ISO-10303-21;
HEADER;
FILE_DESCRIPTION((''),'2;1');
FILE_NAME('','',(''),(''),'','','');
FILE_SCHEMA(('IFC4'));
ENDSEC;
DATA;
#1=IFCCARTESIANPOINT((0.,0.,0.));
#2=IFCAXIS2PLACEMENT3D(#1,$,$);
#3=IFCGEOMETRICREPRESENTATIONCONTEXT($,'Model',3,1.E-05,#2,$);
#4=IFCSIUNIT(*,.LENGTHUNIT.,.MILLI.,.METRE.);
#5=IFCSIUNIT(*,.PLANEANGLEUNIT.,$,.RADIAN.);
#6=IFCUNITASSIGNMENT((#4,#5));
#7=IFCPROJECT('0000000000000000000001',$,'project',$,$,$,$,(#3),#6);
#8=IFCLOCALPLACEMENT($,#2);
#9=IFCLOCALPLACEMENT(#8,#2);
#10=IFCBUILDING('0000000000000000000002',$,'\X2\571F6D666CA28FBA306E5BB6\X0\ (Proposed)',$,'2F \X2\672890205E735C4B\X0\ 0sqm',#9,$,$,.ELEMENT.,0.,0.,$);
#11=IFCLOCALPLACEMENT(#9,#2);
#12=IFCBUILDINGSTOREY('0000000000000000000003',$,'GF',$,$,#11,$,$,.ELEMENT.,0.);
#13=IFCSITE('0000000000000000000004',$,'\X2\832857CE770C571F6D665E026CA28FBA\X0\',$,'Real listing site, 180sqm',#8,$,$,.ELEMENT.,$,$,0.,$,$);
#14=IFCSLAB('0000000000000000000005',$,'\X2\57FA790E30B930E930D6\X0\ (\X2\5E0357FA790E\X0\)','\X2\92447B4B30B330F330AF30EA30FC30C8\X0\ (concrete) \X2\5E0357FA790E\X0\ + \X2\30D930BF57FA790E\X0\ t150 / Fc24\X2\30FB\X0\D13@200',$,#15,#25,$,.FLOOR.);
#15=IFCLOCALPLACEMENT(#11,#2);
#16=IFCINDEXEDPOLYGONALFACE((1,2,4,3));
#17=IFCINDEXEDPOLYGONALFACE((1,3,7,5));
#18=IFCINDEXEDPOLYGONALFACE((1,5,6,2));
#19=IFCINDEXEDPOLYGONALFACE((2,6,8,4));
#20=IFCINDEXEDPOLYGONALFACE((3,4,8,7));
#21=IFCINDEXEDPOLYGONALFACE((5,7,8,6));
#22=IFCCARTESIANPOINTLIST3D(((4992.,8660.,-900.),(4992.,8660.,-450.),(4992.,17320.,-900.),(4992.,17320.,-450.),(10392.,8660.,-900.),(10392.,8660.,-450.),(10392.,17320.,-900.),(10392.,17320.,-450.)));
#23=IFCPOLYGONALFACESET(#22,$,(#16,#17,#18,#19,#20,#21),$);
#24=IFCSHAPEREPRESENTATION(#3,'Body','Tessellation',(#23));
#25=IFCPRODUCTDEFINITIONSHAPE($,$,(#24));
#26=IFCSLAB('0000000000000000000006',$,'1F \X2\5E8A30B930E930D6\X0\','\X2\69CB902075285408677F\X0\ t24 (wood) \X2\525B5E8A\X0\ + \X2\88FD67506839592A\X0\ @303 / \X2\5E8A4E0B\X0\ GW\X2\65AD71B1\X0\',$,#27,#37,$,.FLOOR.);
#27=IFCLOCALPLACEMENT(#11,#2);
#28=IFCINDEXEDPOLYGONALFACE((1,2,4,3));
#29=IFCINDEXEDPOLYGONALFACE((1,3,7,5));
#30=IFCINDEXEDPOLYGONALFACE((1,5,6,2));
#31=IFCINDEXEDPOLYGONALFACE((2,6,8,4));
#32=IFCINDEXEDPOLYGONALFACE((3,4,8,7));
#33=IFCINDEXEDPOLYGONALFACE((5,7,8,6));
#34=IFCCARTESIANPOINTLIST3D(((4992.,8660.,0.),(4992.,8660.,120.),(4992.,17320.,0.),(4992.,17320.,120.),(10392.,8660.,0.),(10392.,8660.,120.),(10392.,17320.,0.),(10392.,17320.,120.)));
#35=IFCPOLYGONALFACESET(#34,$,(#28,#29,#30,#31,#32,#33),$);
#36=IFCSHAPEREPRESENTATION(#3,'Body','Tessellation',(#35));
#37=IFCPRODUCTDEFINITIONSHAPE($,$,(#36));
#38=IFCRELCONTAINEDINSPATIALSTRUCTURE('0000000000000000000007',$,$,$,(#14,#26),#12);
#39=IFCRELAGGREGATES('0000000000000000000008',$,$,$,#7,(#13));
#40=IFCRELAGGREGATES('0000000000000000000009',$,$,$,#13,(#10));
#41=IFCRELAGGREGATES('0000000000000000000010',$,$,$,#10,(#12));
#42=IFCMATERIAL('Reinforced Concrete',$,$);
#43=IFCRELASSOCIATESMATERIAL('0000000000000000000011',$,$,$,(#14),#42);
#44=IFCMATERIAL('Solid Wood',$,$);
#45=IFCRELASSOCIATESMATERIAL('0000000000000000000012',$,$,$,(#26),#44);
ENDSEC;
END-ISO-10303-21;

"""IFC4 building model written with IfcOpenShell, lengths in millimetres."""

from ifc_helpers import new_model, si_unit, frame, frame_2d, origin, place, context, project, spatial, rectangle, extrude, material, element, save


model = new_model("IFC4")

# Units and contexts
model_context = context("Model", 3, precision=1e-05, world=origin())
ifc_project = project(units=[si_unit("LENGTHUNIT", "METRE", prefix="MILLI"), si_unit("PLANEANGLEUNIT", "RADIAN")], contexts=[model_context])

# Site, building, storey
site_placement = place(None, origin())
site = spatial("IfcSite", under=ifc_project, at=site_placement, Name="茨城県土浦市沢辺", ObjectType="Real listing site, 180sqm", CompositionType="ELEMENT", RefElevation=0.0)
building_placement = place(site_placement, origin())
building = spatial("IfcBuilding", under=site, at=building_placement, Name="土浦沢辺の家 (Proposed)", ObjectType="2F 木造平屋 0sqm", CompositionType="ELEMENT", ElevationOfRefHeight=0.0, ElevationOfTerrain=0.0)
storey_placement = place(building_placement, origin())
storey = spatial("IfcBuildingStorey", under=building, at=storey_placement, Name="GF", CompositionType="ELEMENT", Elevation=0.0)

# Slabs
ifc_material_1 = material(Name="Reinforced Concrete")
slab_1_placement = place(storey_placement, frame((2496.0, 4330.0, -450.0)))
element("IfcSlab", 1, at=slab_1_placement, inside=storey, material=ifc_material_1, Name="基礎スラブ (布基礎)", Description="鉄筋コンクリート (concrete) 布基礎 + ベタ基礎 t150 / Fc24・D13@200", PredefinedType="FLOOR", context=model_context, shape_type="SweptSolid", body=[
    extrude(rectangle(XDim=5400.0, YDim=8660.0, at=frame_2d((2700.0, 4330.0))), frame((2496.0, 4330.0, -450.0)), (0.0, 0.0, 1.0), 450.0),
])
ifc_material_2 = material(Name="Solid Wood")
slab_2_placement = place(storey_placement, frame((2496.0, 4330.0, 0.0)))
element("IfcSlab", 2, at=slab_2_placement, inside=storey, material=ifc_material_2, Name="1F 床スラブ", Description="構造用合板 t24 (wood) 剛床 + 製材根太 @303 / 床下 GW断熱", PredefinedType="FLOOR", context=model_context, shape_type="SweptSolid", body=[
    extrude(rectangle(XDim=5400.0, YDim=8660.0, at=frame_2d((2700.0, 4330.0))), frame((2496.0, 4330.0, 0.0)), (0.0, 0.0, 1.0), 120.0),
])

save(model, "model.ifc")
